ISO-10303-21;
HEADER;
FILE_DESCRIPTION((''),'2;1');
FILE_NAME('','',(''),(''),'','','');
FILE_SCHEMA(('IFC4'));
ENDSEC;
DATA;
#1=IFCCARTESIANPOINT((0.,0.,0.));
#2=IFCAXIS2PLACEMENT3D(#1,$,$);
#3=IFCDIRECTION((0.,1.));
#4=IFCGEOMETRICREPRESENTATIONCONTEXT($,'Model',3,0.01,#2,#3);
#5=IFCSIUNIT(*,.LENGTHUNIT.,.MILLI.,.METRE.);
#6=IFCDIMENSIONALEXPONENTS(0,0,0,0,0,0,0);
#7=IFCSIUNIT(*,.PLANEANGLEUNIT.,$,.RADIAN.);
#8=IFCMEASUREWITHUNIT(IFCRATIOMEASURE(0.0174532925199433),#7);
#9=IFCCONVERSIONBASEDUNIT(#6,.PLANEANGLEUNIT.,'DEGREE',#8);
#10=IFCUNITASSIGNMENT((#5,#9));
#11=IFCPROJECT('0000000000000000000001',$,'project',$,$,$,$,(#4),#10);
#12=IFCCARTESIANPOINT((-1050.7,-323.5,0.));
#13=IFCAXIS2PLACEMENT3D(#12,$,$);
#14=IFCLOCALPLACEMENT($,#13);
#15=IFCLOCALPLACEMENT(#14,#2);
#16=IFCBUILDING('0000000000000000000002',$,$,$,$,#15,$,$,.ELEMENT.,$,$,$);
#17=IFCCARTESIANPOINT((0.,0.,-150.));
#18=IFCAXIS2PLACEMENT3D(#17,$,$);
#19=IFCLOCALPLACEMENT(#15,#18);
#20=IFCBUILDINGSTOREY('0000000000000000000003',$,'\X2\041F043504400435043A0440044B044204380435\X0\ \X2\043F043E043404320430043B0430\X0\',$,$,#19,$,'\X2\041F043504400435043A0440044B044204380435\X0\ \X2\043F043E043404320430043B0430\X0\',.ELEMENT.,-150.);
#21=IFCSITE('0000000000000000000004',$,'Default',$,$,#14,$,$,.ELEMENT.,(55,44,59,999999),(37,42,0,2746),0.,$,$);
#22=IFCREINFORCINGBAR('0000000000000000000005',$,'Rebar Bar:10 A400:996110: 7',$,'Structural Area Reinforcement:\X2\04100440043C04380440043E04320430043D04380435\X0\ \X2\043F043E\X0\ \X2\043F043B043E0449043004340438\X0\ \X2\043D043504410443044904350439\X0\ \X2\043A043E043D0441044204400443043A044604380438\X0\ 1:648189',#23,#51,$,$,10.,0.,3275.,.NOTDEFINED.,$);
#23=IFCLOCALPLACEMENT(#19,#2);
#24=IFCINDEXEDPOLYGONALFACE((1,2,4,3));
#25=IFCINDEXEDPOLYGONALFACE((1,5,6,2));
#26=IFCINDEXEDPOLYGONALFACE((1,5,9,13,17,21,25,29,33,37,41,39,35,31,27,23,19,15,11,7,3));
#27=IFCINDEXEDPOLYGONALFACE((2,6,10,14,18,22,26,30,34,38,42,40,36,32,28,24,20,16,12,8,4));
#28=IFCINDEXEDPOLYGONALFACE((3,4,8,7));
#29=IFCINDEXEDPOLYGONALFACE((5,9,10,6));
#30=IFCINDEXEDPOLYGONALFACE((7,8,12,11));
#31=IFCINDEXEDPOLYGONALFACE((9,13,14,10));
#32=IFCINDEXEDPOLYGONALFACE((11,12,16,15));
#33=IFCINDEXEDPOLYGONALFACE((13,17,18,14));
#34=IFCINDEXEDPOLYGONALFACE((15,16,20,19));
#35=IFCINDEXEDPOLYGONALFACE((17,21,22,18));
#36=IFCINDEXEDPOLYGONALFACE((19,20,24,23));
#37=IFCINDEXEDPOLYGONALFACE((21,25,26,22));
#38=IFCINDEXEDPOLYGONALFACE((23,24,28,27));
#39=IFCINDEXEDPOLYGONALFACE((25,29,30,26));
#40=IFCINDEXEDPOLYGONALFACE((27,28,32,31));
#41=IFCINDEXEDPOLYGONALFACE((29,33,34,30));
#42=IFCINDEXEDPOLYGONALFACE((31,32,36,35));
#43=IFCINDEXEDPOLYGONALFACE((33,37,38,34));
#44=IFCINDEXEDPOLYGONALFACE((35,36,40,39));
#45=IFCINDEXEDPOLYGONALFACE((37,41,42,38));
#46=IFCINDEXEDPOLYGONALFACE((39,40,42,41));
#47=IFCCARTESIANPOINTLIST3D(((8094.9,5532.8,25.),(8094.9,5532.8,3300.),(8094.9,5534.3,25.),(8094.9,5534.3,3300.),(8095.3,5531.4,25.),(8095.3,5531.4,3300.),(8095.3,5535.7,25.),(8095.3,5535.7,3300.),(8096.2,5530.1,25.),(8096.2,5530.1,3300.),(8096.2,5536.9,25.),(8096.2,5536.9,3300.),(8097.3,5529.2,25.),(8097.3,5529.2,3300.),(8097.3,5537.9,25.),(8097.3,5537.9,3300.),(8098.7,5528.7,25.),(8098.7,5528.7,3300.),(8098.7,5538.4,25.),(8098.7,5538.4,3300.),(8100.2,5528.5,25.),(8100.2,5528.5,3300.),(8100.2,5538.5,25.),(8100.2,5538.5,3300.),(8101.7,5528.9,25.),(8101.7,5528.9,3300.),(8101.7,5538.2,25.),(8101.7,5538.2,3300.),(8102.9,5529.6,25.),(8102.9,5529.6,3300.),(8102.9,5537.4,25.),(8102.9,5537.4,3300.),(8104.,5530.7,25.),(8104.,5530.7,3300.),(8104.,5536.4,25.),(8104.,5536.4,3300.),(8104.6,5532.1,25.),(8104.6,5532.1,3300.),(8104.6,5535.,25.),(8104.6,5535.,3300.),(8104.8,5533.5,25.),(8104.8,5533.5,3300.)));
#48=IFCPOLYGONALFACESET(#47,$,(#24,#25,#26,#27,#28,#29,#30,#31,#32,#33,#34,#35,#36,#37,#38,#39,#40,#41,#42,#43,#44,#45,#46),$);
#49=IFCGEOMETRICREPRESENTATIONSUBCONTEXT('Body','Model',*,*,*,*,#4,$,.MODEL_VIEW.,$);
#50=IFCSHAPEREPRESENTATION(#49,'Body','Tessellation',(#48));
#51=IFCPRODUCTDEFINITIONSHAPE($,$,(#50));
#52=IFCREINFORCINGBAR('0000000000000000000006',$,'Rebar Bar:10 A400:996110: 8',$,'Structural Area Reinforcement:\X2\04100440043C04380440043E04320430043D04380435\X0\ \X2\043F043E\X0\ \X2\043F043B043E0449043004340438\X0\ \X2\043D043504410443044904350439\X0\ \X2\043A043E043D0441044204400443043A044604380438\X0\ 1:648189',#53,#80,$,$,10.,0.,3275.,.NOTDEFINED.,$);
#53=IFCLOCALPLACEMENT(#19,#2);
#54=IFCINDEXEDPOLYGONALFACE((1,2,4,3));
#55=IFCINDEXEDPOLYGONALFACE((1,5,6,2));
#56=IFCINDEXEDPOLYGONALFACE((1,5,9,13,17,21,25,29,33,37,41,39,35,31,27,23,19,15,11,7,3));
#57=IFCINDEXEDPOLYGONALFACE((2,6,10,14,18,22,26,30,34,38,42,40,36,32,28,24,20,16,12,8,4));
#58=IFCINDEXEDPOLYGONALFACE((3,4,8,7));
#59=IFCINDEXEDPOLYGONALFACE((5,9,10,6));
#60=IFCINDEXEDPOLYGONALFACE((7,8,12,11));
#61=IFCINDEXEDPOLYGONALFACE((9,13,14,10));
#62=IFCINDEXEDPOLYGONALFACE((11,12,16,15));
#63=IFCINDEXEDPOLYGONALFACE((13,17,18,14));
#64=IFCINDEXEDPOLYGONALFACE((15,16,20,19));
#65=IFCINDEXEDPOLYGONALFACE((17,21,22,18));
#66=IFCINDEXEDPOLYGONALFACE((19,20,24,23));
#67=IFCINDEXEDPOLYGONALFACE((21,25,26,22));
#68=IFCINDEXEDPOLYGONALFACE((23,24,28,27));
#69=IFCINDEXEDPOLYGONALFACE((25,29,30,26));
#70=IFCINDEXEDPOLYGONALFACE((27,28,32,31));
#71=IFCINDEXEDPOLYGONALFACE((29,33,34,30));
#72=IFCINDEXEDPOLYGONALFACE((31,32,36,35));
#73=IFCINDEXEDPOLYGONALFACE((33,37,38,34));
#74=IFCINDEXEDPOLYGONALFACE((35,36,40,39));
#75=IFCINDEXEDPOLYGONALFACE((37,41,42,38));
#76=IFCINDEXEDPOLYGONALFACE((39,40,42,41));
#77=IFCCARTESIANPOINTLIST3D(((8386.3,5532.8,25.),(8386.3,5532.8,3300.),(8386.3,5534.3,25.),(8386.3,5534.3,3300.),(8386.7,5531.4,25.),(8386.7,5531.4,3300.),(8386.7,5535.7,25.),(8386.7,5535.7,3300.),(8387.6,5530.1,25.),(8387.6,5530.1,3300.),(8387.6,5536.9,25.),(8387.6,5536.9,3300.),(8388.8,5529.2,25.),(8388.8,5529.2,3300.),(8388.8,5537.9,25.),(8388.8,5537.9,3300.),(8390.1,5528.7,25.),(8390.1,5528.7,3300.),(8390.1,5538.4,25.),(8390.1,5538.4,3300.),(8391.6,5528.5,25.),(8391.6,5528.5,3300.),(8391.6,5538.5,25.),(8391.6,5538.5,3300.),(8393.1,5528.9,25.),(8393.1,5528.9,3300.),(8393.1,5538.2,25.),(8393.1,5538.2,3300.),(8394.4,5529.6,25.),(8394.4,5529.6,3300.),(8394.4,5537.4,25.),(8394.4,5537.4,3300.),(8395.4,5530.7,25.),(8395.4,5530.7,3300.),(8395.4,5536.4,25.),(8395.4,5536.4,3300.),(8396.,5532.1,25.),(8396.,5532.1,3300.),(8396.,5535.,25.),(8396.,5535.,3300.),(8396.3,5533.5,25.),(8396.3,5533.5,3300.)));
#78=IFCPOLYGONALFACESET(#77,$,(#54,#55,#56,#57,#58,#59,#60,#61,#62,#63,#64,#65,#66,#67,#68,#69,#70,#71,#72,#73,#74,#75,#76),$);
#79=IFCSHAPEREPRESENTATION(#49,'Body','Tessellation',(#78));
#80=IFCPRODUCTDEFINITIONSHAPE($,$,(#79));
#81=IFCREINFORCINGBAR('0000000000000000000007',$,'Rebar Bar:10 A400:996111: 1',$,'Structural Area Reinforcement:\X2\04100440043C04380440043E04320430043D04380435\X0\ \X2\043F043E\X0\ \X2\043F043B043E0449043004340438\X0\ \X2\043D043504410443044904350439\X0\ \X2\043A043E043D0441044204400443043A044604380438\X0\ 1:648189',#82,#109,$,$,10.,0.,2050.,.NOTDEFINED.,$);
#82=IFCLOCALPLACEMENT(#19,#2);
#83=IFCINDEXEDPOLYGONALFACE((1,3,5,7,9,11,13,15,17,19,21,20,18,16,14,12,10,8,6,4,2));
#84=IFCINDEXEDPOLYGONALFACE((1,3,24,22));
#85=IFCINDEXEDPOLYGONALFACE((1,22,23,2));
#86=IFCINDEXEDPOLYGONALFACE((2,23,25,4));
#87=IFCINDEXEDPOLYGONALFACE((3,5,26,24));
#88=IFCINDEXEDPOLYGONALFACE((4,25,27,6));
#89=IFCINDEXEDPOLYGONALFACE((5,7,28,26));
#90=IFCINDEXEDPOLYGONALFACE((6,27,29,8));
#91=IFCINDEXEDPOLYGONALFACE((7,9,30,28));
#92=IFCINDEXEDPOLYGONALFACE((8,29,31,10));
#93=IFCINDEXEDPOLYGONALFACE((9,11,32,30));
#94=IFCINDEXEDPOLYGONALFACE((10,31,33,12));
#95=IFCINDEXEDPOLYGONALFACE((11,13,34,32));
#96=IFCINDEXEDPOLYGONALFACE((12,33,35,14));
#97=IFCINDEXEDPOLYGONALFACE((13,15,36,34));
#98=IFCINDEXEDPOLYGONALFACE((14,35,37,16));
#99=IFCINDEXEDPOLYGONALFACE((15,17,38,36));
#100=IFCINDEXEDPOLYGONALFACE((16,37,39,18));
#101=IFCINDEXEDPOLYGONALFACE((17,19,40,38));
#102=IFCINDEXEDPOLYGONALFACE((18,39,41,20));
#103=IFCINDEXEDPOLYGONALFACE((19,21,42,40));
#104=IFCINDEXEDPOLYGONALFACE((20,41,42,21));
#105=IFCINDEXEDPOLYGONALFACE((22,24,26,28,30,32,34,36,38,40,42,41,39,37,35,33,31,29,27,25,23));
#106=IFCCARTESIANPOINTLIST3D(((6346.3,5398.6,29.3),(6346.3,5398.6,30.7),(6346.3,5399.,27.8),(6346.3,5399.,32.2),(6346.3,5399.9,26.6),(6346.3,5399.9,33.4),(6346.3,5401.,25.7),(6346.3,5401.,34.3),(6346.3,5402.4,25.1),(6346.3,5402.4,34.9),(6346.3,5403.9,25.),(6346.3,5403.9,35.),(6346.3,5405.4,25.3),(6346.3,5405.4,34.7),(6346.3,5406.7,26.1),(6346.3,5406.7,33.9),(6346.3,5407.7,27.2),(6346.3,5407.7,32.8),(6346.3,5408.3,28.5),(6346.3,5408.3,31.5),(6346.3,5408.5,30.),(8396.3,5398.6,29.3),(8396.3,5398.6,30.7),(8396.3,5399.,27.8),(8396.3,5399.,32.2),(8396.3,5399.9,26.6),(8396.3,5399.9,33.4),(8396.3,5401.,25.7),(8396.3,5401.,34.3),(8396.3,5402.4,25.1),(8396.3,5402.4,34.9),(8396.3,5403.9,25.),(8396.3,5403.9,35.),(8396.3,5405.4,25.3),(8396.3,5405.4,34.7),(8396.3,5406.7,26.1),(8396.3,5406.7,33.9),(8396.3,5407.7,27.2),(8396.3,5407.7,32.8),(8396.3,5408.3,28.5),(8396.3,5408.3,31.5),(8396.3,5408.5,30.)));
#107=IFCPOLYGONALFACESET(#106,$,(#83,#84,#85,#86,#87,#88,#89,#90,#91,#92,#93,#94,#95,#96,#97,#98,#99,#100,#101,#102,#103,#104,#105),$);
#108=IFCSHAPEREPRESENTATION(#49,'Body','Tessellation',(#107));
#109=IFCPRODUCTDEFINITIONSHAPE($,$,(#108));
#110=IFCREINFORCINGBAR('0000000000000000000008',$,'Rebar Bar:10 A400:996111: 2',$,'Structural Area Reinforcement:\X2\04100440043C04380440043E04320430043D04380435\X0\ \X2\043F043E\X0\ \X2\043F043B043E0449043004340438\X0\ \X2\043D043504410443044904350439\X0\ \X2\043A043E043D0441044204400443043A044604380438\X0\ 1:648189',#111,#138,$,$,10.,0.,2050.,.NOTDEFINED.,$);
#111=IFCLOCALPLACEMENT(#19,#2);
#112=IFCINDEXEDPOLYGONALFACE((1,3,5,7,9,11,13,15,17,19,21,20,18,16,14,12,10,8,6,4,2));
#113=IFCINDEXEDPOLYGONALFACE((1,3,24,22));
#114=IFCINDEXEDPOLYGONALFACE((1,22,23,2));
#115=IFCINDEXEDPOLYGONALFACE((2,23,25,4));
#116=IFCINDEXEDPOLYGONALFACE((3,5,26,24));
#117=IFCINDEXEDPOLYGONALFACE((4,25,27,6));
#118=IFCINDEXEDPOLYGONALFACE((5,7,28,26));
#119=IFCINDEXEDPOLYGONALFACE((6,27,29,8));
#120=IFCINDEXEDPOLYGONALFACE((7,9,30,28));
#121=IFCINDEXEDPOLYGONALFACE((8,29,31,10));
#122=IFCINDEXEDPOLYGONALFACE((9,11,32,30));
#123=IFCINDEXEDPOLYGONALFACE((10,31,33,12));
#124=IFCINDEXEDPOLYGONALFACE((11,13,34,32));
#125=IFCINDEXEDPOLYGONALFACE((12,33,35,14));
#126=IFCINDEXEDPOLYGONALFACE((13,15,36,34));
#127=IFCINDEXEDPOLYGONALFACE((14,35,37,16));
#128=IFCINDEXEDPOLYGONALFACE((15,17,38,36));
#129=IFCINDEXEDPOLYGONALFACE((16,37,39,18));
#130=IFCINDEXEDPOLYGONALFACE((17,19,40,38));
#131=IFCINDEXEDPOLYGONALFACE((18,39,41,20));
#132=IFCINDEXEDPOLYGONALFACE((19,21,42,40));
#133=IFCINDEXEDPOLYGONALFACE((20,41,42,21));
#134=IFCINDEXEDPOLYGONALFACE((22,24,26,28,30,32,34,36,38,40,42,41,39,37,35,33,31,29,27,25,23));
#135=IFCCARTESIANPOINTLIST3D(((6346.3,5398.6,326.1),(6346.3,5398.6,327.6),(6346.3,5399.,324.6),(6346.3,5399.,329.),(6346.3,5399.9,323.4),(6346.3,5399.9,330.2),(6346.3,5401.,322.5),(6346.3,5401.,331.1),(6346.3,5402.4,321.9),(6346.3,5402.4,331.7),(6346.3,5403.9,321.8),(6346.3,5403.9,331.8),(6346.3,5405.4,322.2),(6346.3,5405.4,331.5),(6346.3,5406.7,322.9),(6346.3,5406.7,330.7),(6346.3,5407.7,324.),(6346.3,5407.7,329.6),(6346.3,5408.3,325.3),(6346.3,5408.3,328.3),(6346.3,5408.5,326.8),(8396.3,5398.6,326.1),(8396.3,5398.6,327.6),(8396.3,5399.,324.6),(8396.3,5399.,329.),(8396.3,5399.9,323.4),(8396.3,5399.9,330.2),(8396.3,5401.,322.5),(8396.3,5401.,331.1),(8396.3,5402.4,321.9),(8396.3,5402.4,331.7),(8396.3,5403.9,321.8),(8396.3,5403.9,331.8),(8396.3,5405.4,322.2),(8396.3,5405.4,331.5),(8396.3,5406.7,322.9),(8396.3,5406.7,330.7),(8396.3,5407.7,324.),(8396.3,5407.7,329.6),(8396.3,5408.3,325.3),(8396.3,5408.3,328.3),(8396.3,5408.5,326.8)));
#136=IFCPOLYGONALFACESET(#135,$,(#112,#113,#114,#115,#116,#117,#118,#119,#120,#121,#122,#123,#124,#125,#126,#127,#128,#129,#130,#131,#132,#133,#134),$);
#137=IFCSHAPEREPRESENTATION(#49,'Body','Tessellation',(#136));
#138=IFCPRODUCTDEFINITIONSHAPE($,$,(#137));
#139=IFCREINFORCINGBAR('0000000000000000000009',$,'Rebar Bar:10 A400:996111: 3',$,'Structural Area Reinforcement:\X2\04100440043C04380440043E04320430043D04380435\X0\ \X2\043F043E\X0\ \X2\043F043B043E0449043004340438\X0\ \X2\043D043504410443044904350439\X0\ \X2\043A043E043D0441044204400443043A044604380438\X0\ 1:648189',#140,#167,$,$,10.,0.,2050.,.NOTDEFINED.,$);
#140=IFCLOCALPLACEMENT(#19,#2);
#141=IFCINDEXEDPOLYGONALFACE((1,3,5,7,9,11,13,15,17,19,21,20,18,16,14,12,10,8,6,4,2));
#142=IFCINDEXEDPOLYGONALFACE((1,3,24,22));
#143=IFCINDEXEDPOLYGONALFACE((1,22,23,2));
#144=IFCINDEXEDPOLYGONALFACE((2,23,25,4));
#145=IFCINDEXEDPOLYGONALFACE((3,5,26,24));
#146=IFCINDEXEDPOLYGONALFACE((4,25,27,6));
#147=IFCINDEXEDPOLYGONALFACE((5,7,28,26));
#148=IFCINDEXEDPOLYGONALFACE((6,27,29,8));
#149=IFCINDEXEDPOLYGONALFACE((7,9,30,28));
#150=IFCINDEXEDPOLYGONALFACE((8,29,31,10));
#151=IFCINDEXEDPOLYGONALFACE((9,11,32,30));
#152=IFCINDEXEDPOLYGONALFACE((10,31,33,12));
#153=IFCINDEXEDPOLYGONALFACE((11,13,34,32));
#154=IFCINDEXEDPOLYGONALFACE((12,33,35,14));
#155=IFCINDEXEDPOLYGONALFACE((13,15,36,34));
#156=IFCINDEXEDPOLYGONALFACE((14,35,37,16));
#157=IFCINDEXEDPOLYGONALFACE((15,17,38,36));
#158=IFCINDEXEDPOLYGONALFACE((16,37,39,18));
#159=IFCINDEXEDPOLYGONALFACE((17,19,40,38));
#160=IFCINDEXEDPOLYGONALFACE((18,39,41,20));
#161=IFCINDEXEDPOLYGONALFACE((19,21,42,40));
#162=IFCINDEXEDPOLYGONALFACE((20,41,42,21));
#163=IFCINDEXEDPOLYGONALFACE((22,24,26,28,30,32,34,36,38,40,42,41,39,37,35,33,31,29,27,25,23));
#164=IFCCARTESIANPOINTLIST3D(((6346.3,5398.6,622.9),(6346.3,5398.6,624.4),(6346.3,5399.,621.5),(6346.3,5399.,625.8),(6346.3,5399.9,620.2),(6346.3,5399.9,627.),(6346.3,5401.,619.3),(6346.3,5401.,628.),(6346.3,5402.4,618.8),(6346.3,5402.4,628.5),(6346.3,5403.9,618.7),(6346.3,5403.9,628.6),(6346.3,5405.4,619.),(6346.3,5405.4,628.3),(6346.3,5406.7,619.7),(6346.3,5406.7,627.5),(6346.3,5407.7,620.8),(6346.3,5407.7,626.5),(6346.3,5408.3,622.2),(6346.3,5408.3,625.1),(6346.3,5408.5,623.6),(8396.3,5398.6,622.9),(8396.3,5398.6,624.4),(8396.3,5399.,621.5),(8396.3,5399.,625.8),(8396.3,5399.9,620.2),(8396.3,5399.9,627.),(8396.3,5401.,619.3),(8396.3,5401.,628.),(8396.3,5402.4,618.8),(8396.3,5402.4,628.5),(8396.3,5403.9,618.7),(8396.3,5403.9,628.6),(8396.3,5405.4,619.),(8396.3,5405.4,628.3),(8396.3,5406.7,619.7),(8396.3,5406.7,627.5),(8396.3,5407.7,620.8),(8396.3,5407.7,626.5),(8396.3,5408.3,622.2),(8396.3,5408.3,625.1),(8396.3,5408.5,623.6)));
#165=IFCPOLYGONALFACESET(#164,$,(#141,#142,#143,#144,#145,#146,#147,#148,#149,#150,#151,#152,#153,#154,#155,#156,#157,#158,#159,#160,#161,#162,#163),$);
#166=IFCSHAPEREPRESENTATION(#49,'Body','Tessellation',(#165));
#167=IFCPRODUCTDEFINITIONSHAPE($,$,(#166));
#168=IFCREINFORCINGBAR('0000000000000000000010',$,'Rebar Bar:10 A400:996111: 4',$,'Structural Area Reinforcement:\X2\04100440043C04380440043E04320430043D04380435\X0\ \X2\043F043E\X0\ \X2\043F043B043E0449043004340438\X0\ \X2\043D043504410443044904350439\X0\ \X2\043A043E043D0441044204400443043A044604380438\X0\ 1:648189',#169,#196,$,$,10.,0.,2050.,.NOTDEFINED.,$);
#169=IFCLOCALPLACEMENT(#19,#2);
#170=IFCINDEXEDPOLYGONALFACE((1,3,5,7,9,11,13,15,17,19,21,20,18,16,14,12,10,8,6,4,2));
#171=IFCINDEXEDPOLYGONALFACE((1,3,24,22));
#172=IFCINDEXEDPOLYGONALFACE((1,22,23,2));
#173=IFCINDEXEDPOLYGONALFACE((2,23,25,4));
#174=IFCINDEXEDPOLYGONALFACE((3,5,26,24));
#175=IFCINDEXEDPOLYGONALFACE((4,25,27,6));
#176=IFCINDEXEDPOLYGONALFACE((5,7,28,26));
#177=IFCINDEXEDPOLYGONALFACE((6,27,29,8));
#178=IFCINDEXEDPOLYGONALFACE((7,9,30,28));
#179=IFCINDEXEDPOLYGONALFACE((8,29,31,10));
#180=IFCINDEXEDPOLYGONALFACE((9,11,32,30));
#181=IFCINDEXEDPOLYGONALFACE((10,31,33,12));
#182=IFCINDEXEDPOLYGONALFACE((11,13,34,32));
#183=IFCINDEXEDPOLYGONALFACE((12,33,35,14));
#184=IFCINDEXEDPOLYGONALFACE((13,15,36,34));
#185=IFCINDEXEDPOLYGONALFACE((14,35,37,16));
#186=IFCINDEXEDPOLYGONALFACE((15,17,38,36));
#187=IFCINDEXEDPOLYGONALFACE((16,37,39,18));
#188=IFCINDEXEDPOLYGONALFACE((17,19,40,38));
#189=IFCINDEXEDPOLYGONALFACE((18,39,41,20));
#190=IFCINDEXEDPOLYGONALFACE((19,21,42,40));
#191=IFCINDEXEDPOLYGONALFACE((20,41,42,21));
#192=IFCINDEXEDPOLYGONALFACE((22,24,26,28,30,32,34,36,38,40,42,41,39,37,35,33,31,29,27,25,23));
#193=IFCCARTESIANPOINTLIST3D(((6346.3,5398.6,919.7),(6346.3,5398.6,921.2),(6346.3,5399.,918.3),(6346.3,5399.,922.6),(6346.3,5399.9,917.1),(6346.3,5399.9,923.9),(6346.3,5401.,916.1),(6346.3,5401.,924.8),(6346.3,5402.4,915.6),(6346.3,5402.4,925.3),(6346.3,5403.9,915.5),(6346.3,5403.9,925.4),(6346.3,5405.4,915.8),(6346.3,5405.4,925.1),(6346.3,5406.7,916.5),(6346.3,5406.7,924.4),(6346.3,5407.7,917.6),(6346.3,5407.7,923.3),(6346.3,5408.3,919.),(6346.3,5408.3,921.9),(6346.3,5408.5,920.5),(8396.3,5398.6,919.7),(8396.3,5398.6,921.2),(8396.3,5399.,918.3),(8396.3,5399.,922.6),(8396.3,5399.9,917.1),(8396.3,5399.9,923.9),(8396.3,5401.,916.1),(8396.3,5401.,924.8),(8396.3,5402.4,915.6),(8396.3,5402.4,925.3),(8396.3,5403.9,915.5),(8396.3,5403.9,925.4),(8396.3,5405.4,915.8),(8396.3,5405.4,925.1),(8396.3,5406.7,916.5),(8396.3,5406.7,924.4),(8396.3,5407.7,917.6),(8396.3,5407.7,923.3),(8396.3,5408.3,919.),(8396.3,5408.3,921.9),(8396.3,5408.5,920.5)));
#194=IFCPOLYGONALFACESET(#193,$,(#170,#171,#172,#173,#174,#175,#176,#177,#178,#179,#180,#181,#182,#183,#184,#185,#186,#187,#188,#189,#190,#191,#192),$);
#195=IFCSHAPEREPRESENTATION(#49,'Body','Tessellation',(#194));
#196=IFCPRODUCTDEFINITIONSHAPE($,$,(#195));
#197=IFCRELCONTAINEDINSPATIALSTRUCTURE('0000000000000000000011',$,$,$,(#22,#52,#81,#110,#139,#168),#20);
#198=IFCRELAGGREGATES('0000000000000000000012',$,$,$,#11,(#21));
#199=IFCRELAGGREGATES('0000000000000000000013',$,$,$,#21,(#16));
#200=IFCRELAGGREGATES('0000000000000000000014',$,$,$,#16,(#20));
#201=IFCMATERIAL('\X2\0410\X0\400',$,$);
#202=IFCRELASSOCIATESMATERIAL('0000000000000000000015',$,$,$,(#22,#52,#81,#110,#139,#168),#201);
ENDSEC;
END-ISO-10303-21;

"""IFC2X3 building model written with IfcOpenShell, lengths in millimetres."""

from ifc_helpers import new_model, entity, si_unit, converted_unit, direction, frame, origin, place, context, subcontext, project, spatial, material, element, save


model = new_model("IFC2X3")

# Units and contexts
model_context = context("Model", 3, precision=0.01, world=origin(), true_north=direction((0.0, 1.0)))
body_context = subcontext(model_context, "Body", "Model", "MODEL_VIEW")
ifc_project = project(units=[si_unit("LENGTHUNIT", "METRE", prefix="MILLI"), converted_unit("PLANEANGLEUNIT", "DEGREE", entity("IfcRatioMeasure", 0.0174532925199433), si_unit("PLANEANGLEUNIT", "RADIAN"), dimensions=[0, 0, 0, 0, 0, 0, 0])], contexts=[model_context])

# Site, building, storey
site_placement = place(None, frame((-1050.7, -323.5, 0.0)))
site = spatial("IfcSite", under=ifc_project, at=site_placement, Name="Default", CompositionType="ELEMENT", RefLatitude=(55, 44, 59, 999999), RefLongitude=(37, 42, 0, 2746), RefElevation=0.0)
building_placement = place(site_placement, origin())
building = spatial("IfcBuilding", under=site, at=building_placement, CompositionType="ELEMENT")
storey_placement = place(building_placement, frame((0.0, 0.0, -150.0)))
storey = spatial("IfcBuildingStorey", under=building, at=storey_placement, Name="Перекрытие подвала", LongName="Перекрытие подвала", CompositionType="ELEMENT", Elevation=-150.0)

# Reinforcing bars
ifc_material = material(Name="А400")
reinforcing_bar_1_placement = place(storey_placement, origin())
element("IfcReinforcingBar", 1, at=reinforcing_bar_1_placement, inside=storey, material=ifc_material, Name="Rebar Bar:10 A400:996110: 7", ObjectType="Structural Area Reinforcement:Армирование по площади несущей конструкции 1:648189", BarLength=3275.0, BarRole="NOTDEFINED", CrossSectionArea=0.0, NominalDiameter=10.0, context=body_context, shape_type="AdvancedSweptSolid", body=[
    entity("IfcSweptDiskSolid", entity("IfcCompositeCurve", [entity("IfcCompositeCurveSegment", "CONTINUOUS", True, entity("IfcPolyline", [entity("IfcCartesianPoint", [8099.8, 5533.5, 25.0]), entity("IfcCartesianPoint", [8099.8, 5533.5, 3300.0])]))], False), 5.0, None, 0.0, 1.0),
])
reinforcing_bar_2_placement = place(storey_placement, origin())
element("IfcReinforcingBar", 2, at=reinforcing_bar_2_placement, inside=storey, material=ifc_material, Name="Rebar Bar:10 A400:996110: 8", ObjectType="Structural Area Reinforcement:Армирование по площади несущей конструкции 1:648189", BarLength=3275.0, BarRole="NOTDEFINED", CrossSectionArea=0.0, NominalDiameter=10.0, context=body_context, shape_type="AdvancedSweptSolid", body=[
    entity("IfcSweptDiskSolid", entity("IfcCompositeCurve", [entity("IfcCompositeCurveSegment", "CONTINUOUS", True, entity("IfcPolyline", [entity("IfcCartesianPoint", [8391.3, 5533.5, 25.0]), entity("IfcCartesianPoint", [8391.3, 5533.5, 3300.0])]))], False), 5.0, None, 0.0, 1.0),
])
reinforcing_bar_3_placement = place(storey_placement, origin())
element("IfcReinforcingBar", 3, at=reinforcing_bar_3_placement, inside=storey, material=ifc_material, Name="Rebar Bar:10 A400:996111: 1", ObjectType="Structural Area Reinforcement:Армирование по площади несущей конструкции 1:648189", BarLength=2050.0, BarRole="NOTDEFINED", CrossSectionArea=0.0, NominalDiameter=10.0, context=body_context, shape_type="AdvancedSweptSolid", body=[
    entity("IfcSweptDiskSolid", entity("IfcCompositeCurve", [entity("IfcCompositeCurveSegment", "CONTINUOUS", True, entity("IfcPolyline", [entity("IfcCartesianPoint", [6346.3, 5403.5, 30.0]), entity("IfcCartesianPoint", [8396.3, 5403.5, 30.0])]))], False), 5.0, None, 0.0, 1.0),
])
reinforcing_bar_4_placement = place(storey_placement, origin())
element("IfcReinforcingBar", 4, at=reinforcing_bar_4_placement, inside=storey, material=ifc_material, Name="Rebar Bar:10 A400:996111: 2", ObjectType="Structural Area Reinforcement:Армирование по площади несущей конструкции 1:648189", BarLength=2050.0, BarRole="NOTDEFINED", CrossSectionArea=0.0, NominalDiameter=10.0, context=body_context, shape_type="AdvancedSweptSolid", body=[
    entity("IfcSweptDiskSolid", entity("IfcCompositeCurve", [entity("IfcCompositeCurveSegment", "CONTINUOUS", True, entity("IfcPolyline", [entity("IfcCartesianPoint", [6346.3, 5403.5, 326.8]), entity("IfcCartesianPoint", [8396.3, 5403.5, 326.8])]))], False), 5.0, None, 0.0, 1.0),
])
reinforcing_bar_5_placement = place(storey_placement, origin())
element("IfcReinforcingBar", 5, at=reinforcing_bar_5_placement, inside=storey, material=ifc_material, Name="Rebar Bar:10 A400:996111: 3", ObjectType="Structural Area Reinforcement:Армирование по площади несущей конструкции 1:648189", BarLength=2050.0, BarRole="NOTDEFINED", CrossSectionArea=0.0, NominalDiameter=10.0, context=body_context, shape_type="AdvancedSweptSolid", body=[
    entity("IfcSweptDiskSolid", entity("IfcCompositeCurve", [entity("IfcCompositeCurveSegment", "CONTINUOUS", True, entity("IfcPolyline", [entity("IfcCartesianPoint", [6346.3, 5403.5, 623.6]), entity("IfcCartesianPoint", [8396.3, 5403.5, 623.6])]))], False), 5.0, None, 0.0, 1.0),
])
reinforcing_bar_6_placement = place(storey_placement, origin())
element("IfcReinforcingBar", 6, at=reinforcing_bar_6_placement, inside=storey, material=ifc_material, Name="Rebar Bar:10 A400:996111: 4", ObjectType="Structural Area Reinforcement:Армирование по площади несущей конструкции 1:648189", BarLength=2050.0, BarRole="NOTDEFINED", CrossSectionArea=0.0, NominalDiameter=10.0, context=body_context, shape_type="AdvancedSweptSolid", body=[
    entity("IfcSweptDiskSolid", entity("IfcCompositeCurve", [entity("IfcCompositeCurveSegment", "CONTINUOUS", True, entity("IfcPolyline", [entity("IfcCartesianPoint", [6346.3, 5403.5, 920.5]), entity("IfcCartesianPoint", [8396.3, 5403.5, 920.5])]))], False), 5.0, None, 0.0, 1.0),
])

save(model, "model.ifc")
